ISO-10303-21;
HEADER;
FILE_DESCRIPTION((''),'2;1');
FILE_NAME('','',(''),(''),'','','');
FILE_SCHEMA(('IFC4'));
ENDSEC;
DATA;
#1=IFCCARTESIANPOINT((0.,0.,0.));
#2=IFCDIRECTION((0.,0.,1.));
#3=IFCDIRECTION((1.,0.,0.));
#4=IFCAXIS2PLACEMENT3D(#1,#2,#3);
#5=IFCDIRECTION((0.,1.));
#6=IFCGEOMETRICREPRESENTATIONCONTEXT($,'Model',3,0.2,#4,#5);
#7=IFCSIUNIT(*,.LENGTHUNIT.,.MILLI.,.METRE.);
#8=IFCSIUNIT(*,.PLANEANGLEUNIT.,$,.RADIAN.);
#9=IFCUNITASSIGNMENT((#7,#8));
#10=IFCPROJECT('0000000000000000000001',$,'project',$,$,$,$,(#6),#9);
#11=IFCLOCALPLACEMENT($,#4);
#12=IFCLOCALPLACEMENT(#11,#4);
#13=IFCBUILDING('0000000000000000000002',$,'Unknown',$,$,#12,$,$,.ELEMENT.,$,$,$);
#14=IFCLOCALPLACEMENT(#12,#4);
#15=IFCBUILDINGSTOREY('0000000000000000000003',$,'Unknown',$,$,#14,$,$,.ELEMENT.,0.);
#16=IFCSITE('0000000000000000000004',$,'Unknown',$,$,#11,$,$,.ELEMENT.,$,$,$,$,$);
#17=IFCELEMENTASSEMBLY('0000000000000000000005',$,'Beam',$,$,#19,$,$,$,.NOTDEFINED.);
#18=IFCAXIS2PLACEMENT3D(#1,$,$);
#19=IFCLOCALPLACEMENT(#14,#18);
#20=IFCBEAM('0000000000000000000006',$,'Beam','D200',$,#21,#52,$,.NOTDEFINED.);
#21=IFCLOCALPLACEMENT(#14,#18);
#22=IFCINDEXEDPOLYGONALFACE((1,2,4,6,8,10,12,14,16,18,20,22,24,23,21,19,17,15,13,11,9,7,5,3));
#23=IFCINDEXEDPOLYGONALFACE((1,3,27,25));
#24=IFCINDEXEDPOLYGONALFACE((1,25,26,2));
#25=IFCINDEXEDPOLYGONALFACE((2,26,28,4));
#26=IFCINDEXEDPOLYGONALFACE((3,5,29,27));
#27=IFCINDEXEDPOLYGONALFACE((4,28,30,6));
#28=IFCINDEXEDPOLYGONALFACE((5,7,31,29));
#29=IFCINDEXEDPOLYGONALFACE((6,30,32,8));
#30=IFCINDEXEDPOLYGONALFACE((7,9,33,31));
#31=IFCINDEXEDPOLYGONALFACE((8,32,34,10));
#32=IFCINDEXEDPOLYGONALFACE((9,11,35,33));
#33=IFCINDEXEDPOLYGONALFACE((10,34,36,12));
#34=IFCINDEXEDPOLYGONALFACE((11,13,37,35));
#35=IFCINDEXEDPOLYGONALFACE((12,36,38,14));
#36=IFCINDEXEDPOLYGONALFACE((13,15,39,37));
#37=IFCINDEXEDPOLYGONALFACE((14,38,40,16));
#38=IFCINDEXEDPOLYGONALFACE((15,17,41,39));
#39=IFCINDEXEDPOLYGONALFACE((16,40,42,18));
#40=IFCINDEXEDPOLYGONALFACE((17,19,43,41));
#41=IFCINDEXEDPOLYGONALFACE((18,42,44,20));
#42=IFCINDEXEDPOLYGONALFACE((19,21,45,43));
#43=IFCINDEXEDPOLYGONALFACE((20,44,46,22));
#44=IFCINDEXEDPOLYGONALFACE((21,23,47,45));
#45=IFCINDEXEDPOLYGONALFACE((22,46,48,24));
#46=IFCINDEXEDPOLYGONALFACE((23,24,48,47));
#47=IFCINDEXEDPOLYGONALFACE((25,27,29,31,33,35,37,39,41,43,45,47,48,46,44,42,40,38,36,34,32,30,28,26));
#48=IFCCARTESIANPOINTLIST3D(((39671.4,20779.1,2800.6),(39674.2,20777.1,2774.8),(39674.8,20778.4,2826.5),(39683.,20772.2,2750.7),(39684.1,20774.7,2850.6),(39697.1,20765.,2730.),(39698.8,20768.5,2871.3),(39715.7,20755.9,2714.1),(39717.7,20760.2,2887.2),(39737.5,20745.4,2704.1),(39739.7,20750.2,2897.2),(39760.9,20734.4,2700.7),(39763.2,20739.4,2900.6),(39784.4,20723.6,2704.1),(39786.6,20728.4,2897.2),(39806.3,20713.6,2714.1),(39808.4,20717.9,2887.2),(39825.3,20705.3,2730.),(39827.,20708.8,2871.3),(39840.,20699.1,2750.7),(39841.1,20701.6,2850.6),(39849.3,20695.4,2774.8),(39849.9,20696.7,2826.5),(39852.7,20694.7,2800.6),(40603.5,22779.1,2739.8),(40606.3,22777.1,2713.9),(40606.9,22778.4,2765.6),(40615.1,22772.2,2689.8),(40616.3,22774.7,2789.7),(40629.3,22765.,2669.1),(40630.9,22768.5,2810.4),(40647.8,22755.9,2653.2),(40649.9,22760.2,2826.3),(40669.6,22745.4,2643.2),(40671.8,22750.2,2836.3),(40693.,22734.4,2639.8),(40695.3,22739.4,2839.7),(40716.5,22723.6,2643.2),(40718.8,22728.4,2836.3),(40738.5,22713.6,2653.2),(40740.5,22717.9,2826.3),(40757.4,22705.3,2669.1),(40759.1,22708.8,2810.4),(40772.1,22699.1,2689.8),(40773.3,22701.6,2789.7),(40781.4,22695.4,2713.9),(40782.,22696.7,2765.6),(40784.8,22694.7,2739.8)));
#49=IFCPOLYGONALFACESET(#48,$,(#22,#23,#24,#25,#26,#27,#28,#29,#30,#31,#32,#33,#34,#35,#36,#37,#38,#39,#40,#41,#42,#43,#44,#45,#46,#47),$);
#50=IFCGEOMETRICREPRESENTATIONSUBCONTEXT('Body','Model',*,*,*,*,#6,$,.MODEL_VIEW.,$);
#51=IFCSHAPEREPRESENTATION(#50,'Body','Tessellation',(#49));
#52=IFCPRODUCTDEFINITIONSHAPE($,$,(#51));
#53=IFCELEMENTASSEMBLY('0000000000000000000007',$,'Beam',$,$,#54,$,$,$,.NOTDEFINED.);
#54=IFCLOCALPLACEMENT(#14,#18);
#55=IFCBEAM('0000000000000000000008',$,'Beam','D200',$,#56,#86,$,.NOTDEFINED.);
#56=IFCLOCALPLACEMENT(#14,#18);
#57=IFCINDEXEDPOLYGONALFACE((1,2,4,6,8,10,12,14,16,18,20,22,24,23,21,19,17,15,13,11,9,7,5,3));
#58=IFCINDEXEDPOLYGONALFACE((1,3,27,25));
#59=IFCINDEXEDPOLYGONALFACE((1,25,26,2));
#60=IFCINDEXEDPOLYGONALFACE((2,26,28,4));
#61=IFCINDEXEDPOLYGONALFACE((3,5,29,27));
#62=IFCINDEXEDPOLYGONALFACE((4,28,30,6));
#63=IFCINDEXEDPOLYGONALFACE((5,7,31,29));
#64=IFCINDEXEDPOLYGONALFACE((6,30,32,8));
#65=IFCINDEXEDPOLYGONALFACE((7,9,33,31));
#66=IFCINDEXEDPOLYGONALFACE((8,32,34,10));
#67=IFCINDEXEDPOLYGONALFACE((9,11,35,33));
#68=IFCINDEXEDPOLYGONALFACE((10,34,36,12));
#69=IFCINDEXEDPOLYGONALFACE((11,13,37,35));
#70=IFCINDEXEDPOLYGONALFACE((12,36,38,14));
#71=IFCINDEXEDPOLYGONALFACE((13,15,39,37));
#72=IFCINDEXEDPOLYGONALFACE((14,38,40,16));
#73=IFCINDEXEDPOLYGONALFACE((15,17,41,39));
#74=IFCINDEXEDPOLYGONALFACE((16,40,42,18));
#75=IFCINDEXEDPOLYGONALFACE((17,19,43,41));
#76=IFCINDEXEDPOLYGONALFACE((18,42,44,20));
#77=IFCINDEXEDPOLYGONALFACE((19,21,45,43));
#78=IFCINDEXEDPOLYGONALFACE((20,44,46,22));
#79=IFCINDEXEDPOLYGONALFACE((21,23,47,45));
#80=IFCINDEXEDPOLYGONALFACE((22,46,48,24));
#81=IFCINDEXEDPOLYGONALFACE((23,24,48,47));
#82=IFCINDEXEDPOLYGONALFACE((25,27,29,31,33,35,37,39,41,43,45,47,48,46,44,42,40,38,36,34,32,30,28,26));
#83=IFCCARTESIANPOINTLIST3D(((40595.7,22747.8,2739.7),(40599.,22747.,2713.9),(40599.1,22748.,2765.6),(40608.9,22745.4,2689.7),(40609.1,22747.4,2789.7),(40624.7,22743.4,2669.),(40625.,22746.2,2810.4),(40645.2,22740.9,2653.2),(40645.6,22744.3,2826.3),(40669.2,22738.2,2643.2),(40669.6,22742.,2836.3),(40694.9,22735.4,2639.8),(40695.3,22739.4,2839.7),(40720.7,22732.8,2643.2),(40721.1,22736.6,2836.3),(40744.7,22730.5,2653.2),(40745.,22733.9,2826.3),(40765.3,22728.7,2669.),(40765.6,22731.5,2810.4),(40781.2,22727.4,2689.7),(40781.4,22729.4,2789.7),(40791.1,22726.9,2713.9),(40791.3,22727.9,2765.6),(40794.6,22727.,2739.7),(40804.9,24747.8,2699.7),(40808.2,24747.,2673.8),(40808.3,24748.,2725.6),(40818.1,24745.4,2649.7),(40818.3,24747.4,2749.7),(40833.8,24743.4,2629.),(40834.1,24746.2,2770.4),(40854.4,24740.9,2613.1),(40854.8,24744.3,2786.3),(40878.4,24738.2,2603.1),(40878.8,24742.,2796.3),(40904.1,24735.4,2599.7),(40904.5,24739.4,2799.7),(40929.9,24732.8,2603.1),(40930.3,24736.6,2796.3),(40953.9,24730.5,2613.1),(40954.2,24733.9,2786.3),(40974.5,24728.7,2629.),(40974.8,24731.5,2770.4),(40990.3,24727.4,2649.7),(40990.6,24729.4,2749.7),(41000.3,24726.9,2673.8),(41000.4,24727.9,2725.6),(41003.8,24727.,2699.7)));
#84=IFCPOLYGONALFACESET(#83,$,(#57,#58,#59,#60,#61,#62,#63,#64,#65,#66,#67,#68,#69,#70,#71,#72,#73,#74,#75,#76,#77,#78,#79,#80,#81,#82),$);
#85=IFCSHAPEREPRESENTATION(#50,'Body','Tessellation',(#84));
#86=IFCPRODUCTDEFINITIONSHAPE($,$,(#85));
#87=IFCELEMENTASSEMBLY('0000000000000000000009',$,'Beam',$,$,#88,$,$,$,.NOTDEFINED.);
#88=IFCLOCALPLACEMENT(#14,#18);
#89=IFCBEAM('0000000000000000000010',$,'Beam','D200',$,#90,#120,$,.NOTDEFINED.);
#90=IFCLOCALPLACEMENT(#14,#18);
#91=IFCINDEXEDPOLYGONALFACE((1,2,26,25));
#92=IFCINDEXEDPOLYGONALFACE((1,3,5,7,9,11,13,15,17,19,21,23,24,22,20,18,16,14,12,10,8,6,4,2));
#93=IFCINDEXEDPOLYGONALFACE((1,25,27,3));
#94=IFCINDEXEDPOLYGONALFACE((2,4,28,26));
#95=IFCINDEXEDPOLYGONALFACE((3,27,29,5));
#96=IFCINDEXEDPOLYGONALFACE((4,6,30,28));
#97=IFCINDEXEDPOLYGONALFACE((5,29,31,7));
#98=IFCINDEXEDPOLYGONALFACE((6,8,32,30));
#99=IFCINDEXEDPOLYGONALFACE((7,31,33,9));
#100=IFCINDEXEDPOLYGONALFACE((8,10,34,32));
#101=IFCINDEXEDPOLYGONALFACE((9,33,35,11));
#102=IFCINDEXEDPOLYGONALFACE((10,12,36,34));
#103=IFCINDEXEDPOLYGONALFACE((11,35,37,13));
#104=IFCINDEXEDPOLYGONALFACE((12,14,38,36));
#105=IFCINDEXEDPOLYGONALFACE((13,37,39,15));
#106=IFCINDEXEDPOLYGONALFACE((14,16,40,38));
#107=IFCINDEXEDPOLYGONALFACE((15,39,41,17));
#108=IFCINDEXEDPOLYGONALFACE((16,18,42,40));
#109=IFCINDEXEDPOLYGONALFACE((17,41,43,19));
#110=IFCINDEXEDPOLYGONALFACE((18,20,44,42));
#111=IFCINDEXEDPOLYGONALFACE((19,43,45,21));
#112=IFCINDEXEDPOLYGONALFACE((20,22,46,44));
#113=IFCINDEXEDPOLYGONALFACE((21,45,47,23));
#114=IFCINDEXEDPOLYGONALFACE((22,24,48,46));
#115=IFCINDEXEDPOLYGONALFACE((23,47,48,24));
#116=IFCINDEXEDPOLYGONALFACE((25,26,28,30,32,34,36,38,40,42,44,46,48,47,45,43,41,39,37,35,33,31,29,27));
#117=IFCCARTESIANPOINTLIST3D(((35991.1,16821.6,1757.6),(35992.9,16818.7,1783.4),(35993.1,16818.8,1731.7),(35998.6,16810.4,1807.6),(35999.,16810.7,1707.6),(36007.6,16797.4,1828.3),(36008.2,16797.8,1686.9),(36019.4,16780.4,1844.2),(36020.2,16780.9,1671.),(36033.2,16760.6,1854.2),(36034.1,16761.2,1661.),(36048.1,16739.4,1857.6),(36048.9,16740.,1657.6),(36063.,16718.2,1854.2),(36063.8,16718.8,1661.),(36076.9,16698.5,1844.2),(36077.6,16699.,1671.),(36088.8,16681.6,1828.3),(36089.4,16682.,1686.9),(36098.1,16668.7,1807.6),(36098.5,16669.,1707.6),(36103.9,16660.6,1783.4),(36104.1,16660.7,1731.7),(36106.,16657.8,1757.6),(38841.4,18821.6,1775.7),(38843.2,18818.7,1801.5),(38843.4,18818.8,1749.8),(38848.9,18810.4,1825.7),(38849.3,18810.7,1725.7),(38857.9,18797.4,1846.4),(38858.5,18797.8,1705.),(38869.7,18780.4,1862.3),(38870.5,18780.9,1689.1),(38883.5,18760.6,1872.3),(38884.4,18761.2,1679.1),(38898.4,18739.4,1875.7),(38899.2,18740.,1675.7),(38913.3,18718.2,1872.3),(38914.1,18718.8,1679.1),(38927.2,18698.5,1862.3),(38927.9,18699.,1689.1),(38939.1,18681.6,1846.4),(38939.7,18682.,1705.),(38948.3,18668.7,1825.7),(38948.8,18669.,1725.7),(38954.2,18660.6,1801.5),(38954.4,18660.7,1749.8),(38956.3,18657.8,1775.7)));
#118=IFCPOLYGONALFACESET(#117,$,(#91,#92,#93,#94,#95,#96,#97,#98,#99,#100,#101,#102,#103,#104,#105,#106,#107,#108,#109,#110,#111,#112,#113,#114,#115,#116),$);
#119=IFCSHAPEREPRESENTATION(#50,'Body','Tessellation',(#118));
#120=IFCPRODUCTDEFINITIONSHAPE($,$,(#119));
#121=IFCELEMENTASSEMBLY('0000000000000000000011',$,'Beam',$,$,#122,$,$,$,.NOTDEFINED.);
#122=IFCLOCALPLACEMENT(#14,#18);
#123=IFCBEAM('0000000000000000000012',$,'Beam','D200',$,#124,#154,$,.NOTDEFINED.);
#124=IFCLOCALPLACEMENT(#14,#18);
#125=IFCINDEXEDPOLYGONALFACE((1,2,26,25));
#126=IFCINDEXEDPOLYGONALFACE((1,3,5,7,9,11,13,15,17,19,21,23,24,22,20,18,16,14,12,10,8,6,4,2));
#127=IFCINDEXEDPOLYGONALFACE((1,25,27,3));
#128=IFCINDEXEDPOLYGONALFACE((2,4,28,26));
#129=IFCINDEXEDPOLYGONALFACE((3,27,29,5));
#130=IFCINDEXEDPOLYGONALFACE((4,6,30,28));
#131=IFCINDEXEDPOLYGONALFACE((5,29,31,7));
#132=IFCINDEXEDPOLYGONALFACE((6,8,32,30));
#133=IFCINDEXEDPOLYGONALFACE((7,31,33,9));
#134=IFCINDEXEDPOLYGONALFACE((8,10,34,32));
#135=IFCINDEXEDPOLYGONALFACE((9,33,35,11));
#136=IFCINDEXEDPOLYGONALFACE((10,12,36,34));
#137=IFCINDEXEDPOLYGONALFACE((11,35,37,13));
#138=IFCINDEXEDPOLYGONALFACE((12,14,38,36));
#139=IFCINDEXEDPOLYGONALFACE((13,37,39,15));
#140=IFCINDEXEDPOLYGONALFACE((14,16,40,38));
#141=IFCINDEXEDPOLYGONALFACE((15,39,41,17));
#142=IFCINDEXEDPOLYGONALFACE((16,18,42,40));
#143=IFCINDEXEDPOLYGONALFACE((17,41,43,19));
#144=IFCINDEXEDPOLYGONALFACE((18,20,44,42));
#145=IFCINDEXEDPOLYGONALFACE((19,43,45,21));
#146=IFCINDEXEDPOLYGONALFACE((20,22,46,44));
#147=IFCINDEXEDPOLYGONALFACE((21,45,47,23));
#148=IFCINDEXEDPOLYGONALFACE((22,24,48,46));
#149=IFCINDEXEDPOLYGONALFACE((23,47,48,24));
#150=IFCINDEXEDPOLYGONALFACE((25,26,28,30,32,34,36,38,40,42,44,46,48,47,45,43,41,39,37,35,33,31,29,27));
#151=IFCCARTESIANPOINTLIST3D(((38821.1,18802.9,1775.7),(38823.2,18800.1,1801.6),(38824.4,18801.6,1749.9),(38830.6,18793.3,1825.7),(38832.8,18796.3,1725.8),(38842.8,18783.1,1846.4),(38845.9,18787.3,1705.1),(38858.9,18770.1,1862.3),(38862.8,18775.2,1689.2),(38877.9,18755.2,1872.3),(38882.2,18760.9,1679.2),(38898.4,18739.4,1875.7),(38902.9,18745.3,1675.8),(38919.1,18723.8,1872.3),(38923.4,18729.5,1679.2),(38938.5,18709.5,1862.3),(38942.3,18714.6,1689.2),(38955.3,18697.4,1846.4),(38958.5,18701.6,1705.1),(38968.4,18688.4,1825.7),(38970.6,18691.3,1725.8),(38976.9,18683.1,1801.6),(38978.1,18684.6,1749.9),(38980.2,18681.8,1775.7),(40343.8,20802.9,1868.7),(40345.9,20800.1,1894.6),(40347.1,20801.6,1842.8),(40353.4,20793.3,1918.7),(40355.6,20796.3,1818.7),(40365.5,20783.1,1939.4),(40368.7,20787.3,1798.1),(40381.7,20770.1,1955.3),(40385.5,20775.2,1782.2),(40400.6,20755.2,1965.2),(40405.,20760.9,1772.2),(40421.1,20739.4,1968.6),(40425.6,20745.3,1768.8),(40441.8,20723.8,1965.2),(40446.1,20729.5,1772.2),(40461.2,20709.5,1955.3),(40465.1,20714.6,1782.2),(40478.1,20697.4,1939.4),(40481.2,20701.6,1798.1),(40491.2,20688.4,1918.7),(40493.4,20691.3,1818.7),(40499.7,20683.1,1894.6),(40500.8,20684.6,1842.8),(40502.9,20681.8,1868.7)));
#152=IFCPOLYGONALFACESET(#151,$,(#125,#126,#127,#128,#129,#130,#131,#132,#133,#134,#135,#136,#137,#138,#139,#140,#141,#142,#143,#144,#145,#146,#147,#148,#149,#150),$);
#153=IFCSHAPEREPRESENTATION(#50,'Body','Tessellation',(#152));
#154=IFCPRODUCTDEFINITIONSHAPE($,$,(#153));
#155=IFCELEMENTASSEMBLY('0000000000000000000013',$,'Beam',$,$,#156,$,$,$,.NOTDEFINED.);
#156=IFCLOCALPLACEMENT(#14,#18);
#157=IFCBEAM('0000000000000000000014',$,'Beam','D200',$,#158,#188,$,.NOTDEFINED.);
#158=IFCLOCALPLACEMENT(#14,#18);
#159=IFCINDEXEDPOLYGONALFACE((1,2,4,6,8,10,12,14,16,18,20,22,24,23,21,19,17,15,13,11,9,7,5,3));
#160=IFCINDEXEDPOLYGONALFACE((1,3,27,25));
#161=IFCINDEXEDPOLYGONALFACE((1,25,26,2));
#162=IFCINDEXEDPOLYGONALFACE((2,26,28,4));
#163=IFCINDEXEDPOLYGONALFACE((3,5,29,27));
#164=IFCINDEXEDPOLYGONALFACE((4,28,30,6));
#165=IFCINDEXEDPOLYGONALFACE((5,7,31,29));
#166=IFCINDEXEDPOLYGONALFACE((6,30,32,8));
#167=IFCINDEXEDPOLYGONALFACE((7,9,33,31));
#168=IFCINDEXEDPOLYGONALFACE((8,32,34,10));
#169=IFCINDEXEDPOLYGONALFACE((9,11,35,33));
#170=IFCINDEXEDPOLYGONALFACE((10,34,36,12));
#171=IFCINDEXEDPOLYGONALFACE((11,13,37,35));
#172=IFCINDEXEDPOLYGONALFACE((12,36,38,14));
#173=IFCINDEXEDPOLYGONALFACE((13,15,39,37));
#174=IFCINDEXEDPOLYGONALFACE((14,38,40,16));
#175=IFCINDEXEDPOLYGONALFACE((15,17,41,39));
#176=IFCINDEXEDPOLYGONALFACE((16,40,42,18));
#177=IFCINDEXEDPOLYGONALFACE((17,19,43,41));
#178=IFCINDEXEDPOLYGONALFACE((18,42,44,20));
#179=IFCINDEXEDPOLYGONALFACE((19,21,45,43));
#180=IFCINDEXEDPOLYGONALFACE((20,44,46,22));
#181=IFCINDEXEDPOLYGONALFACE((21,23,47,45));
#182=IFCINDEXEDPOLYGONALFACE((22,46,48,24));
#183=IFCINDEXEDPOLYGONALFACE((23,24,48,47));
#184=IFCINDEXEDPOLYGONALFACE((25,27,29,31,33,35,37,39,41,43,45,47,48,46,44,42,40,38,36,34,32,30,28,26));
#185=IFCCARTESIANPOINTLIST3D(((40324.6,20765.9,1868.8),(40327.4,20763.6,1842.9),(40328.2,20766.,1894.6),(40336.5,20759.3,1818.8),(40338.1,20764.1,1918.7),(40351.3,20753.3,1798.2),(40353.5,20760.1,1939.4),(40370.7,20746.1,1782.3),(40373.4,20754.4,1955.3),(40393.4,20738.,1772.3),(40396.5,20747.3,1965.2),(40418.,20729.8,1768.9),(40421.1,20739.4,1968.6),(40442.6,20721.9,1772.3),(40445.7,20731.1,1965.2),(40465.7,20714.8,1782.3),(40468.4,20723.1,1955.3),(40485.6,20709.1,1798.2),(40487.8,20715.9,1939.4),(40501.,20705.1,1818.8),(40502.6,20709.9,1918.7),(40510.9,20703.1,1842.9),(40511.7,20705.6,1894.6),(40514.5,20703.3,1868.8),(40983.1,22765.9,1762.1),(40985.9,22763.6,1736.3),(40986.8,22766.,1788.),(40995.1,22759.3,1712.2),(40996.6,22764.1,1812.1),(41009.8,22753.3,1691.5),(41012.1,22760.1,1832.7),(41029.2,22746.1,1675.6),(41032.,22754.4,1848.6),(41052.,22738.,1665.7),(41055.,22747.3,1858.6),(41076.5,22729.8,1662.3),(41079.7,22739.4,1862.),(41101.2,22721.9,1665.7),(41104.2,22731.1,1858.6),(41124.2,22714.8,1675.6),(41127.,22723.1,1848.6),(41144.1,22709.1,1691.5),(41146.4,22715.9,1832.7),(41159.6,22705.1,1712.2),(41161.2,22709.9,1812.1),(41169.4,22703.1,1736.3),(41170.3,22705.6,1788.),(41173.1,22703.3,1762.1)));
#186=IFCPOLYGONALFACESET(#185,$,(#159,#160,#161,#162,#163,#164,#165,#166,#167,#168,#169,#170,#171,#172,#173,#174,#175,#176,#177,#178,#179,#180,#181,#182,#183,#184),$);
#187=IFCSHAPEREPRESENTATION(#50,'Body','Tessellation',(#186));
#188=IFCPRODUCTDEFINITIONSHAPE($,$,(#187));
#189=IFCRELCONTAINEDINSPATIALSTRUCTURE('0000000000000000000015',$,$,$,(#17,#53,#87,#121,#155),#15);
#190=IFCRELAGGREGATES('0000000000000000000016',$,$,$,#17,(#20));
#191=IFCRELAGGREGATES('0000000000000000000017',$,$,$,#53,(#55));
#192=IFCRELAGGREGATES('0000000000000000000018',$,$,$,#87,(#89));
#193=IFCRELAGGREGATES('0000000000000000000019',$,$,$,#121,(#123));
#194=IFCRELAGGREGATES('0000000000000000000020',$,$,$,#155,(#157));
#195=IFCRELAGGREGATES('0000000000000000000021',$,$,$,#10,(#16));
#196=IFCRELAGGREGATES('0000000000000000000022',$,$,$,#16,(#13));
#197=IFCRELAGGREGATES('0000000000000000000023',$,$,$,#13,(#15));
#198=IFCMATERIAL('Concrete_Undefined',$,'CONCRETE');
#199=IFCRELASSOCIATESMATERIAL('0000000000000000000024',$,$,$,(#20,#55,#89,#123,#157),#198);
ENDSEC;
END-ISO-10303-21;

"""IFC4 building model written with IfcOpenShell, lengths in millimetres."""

from ifc_helpers import new_model, si_unit, direction, frame, origin_with_axes, place, context, subcontext, project, spatial, line, indexed_curve, outline, extrude, material, element, aggregate, save


model = new_model("IFC4")

# Units and contexts
model_context = context("Model", 3, precision=0.2, world=origin_with_axes(), true_north=direction((0.0, 1.0)))
body_context = subcontext(model_context, "Body", "Model", "MODEL_VIEW")
ifc_project = project(units=[si_unit("LENGTHUNIT", "METRE", prefix="MILLI"), si_unit("PLANEANGLEUNIT", "RADIAN")], contexts=[model_context])

# Site, building, storey
site_placement = place(None, origin_with_axes())
site = spatial("IfcSite", under=ifc_project, at=site_placement, Name="Unknown", CompositionType="ELEMENT")
building_placement = place(site_placement, origin_with_axes())
building = spatial("IfcBuilding", under=site, at=building_placement, Name="Unknown", CompositionType="ELEMENT")
storey_placement = place(building_placement, origin_with_axes())
storey = spatial("IfcBuildingStorey", under=building, at=storey_placement, Name="Unknown", CompositionType="ELEMENT", Elevation=0.0)

# Element assemblies, beams
ifc_material = material(Name="Concrete_Undefined", Category="CONCRETE")
assembly_1_placement = place(storey_placement, frame((40694.2, 22736.9, 2739.8), z_axis=(-0.906391, 0.422439, 0.0), x_axis=(-0.422278, -0.906046, 0.027585)))
assembly_1 = element("IfcElementAssembly", 1, at=assembly_1_placement, inside=storey, Name="Beam", PredefinedType="NOTDEFINED")
beam_1_placement = place(assembly_1_placement, origin_with_axes())
beam_1 = element("IfcBeam", 2, at=beam_1_placement, material=ifc_material, Name="Beam", Description="D200", PredefinedType="NOTDEFINED", context=body_context, shape_type="SolidModel", body=[
    extrude(outline(indexed_curve([(100.0, 0.0), (96.6, 25.9), (86.6, 50.0), (70.7, 70.7), (50.0, 86.6), (25.9, 96.6), (0.0, 100.0), (-25.9, 96.6), (-50.0, 86.6), (-70.7, 70.7), (-86.6, 50.0), (-96.6, 25.9), (-100.0, 0.0), (-96.6, -25.9), (-86.6, -50.0), (-70.7, -70.7), (-50.0, -86.6), (-25.9, -96.6), (0.0, -100.0), (25.9, -96.6), (50.0, -86.6), (70.7, -70.7), (86.6, -50.0), (96.6, -25.9)], segments=[line(1, 2, 3, 4, 5, 6, 7, 8, 9, 10, 11, 12, 13, 14, 15, 16, 17, 18, 19, 20, 21, 22, 23, 24, 1)])), frame((0.0, 0.0, 0.0), z_axis=(-1.0, 0.0, 0.0), x_axis=(0.0, 0.0, 1.0)), (0.0, 0.0, -1.0), 2207.4),
])
aggregate(assembly_1, [beam_1])
assembly_2_placement = place(storey_placement, frame((40904.3, 24737.4, 2699.7), z_axis=(-0.994575, 0.104027, 0.0), x_axis=(-0.104006, -0.994378, 0.019898)))
assembly_2 = element("IfcElementAssembly", 3, at=assembly_2_placement, inside=storey, Name="Beam", PredefinedType="NOTDEFINED")
beam_2_placement = place(assembly_2_placement, origin_with_axes())
beam_2 = element("IfcBeam", 4, at=beam_2_placement, material=ifc_material, Name="Beam", Description="D200", PredefinedType="NOTDEFINED", context=body_context, shape_type="SolidModel", body=[
    extrude(outline(indexed_curve([(100.0, 0.0), (96.6, 25.9), (86.6, 50.0), (70.7, 70.7), (50.0, 86.6), (25.9, 96.6), (0.0, 100.0), (-25.9, 96.6), (-50.0, 86.6), (-70.7, 70.7), (-86.6, 50.0), (-96.6, 25.9), (-100.0, 0.0), (-96.6, -25.9), (-86.6, -50.0), (-70.7, -70.7), (-50.0, -86.6), (-25.9, -96.6), (0.0, -100.0), (25.9, -96.6), (50.0, -86.6), (70.7, -70.7), (86.6, -50.0), (96.6, -25.9)], segments=[line(1, 2, 3, 4, 5, 6, 7, 8, 9, 10, 11, 12, 13, 14, 15, 16, 17, 18, 19, 20, 21, 22, 23, 24, 1)])), frame((0.0, 0.0, 0.0), z_axis=(-1.0, 0.0, 0.0), x_axis=(0.0, 0.0, 1.0)), (0.0, 0.0, -1.0), 2011.3),
])
aggregate(assembly_2, [beam_2])
assembly_3_placement = place(storey_placement, frame((38898.8, 18739.7, 1775.7), z_axis=(-0.574386, 0.818584, 0.0), x_axis=(-0.818573, -0.574379, -0.005196)))
assembly_3 = element("IfcElementAssembly", 5, at=assembly_3_placement, inside=storey, Name="Beam", PredefinedType="NOTDEFINED")
beam_3_placement = place(assembly_3_placement, origin_with_axes())
beam_3 = element("IfcBeam", 6, at=beam_3_placement, material=ifc_material, Name="Beam", Description="D200", PredefinedType="NOTDEFINED", context=body_context, shape_type="SolidModel", body=[
    extrude(outline(indexed_curve([(100.0, 0.0), (96.6, 25.9), (86.6, 50.0), (70.7, 70.7), (50.0, 86.6), (25.9, 96.6), (0.0, 100.0), (-25.9, 96.6), (-50.0, 86.6), (-70.7, 70.7), (-86.6, 50.0), (-96.6, 25.9), (-100.0, 0.0), (-96.6, -25.9), (-86.6, -50.0), (-70.7, -70.7), (-50.0, -86.6), (-25.9, -96.6), (0.0, -100.0), (25.9, -96.6), (50.0, -86.6), (70.7, -70.7), (86.6, -50.0), (96.6, -25.9)], segments=[line(1, 2, 3, 4, 5, 6, 7, 8, 9, 10, 11, 12, 13, 14, 15, 16, 17, 18, 19, 20, 21, 22, 23, 24, 1)])), frame((0.0, 0.0, 0.0), z_axis=(-1.0, 0.0, 0.0), x_axis=(0.0, 0.0, 1.0)), (0.0, 0.0, -1.0), 3482.0),
])
aggregate(assembly_3, [beam_3])
assembly_4_placement = place(storey_placement, frame((40423.4, 20742.3, 1868.7), z_axis=(-0.795634, 0.605778, 0.0), x_axis=(-0.605364, -0.79509, -0.036965)))
assembly_4 = element("IfcElementAssembly", 7, at=assembly_4_placement, inside=storey, Name="Beam", PredefinedType="NOTDEFINED")
beam_4_placement = place(assembly_4_placement, origin_with_axes())
beam_4 = element("IfcBeam", 8, at=beam_4_placement, material=ifc_material, Name="Beam", Description="D200", PredefinedType="NOTDEFINED", context=body_context, shape_type="SolidModel", body=[
    extrude(outline(indexed_curve([(100.0, 0.0), (96.6, 25.9), (86.6, 50.0), (70.7, 70.7), (50.0, 86.6), (25.9, 96.6), (0.0, 100.0), (-25.9, 96.6), (-50.0, 86.6), (-70.7, 70.7), (-86.6, 50.0), (-96.6, 25.9), (-100.0, 0.0), (-96.6, -25.9), (-86.6, -50.0), (-70.7, -70.7), (-50.0, -86.6), (-25.9, -96.6), (0.0, -100.0), (25.9, -96.6), (50.0, -86.6), (70.7, -70.7), (86.6, -50.0), (96.6, -25.9)], segments=[line(1, 2, 3, 4, 5, 6, 7, 8, 9, 10, 11, 12, 13, 14, 15, 16, 17, 18, 19, 20, 21, 22, 23, 24, 1)])), frame((0.0, 0.0, 0.0), z_axis=(-1.0, 0.0, 0.0), x_axis=(0.0, 0.0, 1.0)), (0.0, 0.0, -1.0), 2515.4),
])
aggregate(assembly_4, [beam_4])
assembly_5_placement = place(storey_placement, frame((41078.1, 22734.6, 1762.1), z_axis=(-0.949834, 0.312754, 0.0), x_axis=(-0.312353, -0.948618, 0.050584)))
assembly_5 = element("IfcElementAssembly", 9, at=assembly_5_placement, inside=storey, Name="Beam", PredefinedType="NOTDEFINED")
beam_5_placement = place(assembly_5_placement, origin_with_axes())
beam_5 = element("IfcBeam", 10, at=beam_5_placement, material=ifc_material, Name="Beam", Description="D200", PredefinedType="NOTDEFINED", context=body_context, shape_type="SolidModel", body=[
    extrude(outline(indexed_curve([(100.0, 0.0), (96.6, 25.9), (86.6, 50.0), (70.7, 70.7), (50.0, 86.6), (25.9, 96.6), (0.0, 100.0), (-25.9, 96.6), (-50.0, 86.6), (-70.7, 70.7), (-86.6, 50.0), (-96.6, 25.9), (-100.0, 0.0), (-96.6, -25.9), (-86.6, -50.0), (-70.7, -70.7), (-50.0, -86.6), (-25.9, -96.6), (0.0, -100.0), (25.9, -96.6), (50.0, -86.6), (70.7, -70.7), (86.6, -50.0), (96.6, -25.9)], segments=[line(1, 2, 3, 4, 5, 6, 7, 8, 9, 10, 11, 12, 13, 14, 15, 16, 17, 18, 19, 20, 21, 22, 23, 24, 1)])), frame((0.0, 0.0, 0.0), z_axis=(-1.0, 0.0, 0.0), x_axis=(0.0, 0.0, 1.0)), (0.0, 0.0, -1.0), 2108.3),
])
aggregate(assembly_5, [beam_5])

save(model, "model.ifc")
